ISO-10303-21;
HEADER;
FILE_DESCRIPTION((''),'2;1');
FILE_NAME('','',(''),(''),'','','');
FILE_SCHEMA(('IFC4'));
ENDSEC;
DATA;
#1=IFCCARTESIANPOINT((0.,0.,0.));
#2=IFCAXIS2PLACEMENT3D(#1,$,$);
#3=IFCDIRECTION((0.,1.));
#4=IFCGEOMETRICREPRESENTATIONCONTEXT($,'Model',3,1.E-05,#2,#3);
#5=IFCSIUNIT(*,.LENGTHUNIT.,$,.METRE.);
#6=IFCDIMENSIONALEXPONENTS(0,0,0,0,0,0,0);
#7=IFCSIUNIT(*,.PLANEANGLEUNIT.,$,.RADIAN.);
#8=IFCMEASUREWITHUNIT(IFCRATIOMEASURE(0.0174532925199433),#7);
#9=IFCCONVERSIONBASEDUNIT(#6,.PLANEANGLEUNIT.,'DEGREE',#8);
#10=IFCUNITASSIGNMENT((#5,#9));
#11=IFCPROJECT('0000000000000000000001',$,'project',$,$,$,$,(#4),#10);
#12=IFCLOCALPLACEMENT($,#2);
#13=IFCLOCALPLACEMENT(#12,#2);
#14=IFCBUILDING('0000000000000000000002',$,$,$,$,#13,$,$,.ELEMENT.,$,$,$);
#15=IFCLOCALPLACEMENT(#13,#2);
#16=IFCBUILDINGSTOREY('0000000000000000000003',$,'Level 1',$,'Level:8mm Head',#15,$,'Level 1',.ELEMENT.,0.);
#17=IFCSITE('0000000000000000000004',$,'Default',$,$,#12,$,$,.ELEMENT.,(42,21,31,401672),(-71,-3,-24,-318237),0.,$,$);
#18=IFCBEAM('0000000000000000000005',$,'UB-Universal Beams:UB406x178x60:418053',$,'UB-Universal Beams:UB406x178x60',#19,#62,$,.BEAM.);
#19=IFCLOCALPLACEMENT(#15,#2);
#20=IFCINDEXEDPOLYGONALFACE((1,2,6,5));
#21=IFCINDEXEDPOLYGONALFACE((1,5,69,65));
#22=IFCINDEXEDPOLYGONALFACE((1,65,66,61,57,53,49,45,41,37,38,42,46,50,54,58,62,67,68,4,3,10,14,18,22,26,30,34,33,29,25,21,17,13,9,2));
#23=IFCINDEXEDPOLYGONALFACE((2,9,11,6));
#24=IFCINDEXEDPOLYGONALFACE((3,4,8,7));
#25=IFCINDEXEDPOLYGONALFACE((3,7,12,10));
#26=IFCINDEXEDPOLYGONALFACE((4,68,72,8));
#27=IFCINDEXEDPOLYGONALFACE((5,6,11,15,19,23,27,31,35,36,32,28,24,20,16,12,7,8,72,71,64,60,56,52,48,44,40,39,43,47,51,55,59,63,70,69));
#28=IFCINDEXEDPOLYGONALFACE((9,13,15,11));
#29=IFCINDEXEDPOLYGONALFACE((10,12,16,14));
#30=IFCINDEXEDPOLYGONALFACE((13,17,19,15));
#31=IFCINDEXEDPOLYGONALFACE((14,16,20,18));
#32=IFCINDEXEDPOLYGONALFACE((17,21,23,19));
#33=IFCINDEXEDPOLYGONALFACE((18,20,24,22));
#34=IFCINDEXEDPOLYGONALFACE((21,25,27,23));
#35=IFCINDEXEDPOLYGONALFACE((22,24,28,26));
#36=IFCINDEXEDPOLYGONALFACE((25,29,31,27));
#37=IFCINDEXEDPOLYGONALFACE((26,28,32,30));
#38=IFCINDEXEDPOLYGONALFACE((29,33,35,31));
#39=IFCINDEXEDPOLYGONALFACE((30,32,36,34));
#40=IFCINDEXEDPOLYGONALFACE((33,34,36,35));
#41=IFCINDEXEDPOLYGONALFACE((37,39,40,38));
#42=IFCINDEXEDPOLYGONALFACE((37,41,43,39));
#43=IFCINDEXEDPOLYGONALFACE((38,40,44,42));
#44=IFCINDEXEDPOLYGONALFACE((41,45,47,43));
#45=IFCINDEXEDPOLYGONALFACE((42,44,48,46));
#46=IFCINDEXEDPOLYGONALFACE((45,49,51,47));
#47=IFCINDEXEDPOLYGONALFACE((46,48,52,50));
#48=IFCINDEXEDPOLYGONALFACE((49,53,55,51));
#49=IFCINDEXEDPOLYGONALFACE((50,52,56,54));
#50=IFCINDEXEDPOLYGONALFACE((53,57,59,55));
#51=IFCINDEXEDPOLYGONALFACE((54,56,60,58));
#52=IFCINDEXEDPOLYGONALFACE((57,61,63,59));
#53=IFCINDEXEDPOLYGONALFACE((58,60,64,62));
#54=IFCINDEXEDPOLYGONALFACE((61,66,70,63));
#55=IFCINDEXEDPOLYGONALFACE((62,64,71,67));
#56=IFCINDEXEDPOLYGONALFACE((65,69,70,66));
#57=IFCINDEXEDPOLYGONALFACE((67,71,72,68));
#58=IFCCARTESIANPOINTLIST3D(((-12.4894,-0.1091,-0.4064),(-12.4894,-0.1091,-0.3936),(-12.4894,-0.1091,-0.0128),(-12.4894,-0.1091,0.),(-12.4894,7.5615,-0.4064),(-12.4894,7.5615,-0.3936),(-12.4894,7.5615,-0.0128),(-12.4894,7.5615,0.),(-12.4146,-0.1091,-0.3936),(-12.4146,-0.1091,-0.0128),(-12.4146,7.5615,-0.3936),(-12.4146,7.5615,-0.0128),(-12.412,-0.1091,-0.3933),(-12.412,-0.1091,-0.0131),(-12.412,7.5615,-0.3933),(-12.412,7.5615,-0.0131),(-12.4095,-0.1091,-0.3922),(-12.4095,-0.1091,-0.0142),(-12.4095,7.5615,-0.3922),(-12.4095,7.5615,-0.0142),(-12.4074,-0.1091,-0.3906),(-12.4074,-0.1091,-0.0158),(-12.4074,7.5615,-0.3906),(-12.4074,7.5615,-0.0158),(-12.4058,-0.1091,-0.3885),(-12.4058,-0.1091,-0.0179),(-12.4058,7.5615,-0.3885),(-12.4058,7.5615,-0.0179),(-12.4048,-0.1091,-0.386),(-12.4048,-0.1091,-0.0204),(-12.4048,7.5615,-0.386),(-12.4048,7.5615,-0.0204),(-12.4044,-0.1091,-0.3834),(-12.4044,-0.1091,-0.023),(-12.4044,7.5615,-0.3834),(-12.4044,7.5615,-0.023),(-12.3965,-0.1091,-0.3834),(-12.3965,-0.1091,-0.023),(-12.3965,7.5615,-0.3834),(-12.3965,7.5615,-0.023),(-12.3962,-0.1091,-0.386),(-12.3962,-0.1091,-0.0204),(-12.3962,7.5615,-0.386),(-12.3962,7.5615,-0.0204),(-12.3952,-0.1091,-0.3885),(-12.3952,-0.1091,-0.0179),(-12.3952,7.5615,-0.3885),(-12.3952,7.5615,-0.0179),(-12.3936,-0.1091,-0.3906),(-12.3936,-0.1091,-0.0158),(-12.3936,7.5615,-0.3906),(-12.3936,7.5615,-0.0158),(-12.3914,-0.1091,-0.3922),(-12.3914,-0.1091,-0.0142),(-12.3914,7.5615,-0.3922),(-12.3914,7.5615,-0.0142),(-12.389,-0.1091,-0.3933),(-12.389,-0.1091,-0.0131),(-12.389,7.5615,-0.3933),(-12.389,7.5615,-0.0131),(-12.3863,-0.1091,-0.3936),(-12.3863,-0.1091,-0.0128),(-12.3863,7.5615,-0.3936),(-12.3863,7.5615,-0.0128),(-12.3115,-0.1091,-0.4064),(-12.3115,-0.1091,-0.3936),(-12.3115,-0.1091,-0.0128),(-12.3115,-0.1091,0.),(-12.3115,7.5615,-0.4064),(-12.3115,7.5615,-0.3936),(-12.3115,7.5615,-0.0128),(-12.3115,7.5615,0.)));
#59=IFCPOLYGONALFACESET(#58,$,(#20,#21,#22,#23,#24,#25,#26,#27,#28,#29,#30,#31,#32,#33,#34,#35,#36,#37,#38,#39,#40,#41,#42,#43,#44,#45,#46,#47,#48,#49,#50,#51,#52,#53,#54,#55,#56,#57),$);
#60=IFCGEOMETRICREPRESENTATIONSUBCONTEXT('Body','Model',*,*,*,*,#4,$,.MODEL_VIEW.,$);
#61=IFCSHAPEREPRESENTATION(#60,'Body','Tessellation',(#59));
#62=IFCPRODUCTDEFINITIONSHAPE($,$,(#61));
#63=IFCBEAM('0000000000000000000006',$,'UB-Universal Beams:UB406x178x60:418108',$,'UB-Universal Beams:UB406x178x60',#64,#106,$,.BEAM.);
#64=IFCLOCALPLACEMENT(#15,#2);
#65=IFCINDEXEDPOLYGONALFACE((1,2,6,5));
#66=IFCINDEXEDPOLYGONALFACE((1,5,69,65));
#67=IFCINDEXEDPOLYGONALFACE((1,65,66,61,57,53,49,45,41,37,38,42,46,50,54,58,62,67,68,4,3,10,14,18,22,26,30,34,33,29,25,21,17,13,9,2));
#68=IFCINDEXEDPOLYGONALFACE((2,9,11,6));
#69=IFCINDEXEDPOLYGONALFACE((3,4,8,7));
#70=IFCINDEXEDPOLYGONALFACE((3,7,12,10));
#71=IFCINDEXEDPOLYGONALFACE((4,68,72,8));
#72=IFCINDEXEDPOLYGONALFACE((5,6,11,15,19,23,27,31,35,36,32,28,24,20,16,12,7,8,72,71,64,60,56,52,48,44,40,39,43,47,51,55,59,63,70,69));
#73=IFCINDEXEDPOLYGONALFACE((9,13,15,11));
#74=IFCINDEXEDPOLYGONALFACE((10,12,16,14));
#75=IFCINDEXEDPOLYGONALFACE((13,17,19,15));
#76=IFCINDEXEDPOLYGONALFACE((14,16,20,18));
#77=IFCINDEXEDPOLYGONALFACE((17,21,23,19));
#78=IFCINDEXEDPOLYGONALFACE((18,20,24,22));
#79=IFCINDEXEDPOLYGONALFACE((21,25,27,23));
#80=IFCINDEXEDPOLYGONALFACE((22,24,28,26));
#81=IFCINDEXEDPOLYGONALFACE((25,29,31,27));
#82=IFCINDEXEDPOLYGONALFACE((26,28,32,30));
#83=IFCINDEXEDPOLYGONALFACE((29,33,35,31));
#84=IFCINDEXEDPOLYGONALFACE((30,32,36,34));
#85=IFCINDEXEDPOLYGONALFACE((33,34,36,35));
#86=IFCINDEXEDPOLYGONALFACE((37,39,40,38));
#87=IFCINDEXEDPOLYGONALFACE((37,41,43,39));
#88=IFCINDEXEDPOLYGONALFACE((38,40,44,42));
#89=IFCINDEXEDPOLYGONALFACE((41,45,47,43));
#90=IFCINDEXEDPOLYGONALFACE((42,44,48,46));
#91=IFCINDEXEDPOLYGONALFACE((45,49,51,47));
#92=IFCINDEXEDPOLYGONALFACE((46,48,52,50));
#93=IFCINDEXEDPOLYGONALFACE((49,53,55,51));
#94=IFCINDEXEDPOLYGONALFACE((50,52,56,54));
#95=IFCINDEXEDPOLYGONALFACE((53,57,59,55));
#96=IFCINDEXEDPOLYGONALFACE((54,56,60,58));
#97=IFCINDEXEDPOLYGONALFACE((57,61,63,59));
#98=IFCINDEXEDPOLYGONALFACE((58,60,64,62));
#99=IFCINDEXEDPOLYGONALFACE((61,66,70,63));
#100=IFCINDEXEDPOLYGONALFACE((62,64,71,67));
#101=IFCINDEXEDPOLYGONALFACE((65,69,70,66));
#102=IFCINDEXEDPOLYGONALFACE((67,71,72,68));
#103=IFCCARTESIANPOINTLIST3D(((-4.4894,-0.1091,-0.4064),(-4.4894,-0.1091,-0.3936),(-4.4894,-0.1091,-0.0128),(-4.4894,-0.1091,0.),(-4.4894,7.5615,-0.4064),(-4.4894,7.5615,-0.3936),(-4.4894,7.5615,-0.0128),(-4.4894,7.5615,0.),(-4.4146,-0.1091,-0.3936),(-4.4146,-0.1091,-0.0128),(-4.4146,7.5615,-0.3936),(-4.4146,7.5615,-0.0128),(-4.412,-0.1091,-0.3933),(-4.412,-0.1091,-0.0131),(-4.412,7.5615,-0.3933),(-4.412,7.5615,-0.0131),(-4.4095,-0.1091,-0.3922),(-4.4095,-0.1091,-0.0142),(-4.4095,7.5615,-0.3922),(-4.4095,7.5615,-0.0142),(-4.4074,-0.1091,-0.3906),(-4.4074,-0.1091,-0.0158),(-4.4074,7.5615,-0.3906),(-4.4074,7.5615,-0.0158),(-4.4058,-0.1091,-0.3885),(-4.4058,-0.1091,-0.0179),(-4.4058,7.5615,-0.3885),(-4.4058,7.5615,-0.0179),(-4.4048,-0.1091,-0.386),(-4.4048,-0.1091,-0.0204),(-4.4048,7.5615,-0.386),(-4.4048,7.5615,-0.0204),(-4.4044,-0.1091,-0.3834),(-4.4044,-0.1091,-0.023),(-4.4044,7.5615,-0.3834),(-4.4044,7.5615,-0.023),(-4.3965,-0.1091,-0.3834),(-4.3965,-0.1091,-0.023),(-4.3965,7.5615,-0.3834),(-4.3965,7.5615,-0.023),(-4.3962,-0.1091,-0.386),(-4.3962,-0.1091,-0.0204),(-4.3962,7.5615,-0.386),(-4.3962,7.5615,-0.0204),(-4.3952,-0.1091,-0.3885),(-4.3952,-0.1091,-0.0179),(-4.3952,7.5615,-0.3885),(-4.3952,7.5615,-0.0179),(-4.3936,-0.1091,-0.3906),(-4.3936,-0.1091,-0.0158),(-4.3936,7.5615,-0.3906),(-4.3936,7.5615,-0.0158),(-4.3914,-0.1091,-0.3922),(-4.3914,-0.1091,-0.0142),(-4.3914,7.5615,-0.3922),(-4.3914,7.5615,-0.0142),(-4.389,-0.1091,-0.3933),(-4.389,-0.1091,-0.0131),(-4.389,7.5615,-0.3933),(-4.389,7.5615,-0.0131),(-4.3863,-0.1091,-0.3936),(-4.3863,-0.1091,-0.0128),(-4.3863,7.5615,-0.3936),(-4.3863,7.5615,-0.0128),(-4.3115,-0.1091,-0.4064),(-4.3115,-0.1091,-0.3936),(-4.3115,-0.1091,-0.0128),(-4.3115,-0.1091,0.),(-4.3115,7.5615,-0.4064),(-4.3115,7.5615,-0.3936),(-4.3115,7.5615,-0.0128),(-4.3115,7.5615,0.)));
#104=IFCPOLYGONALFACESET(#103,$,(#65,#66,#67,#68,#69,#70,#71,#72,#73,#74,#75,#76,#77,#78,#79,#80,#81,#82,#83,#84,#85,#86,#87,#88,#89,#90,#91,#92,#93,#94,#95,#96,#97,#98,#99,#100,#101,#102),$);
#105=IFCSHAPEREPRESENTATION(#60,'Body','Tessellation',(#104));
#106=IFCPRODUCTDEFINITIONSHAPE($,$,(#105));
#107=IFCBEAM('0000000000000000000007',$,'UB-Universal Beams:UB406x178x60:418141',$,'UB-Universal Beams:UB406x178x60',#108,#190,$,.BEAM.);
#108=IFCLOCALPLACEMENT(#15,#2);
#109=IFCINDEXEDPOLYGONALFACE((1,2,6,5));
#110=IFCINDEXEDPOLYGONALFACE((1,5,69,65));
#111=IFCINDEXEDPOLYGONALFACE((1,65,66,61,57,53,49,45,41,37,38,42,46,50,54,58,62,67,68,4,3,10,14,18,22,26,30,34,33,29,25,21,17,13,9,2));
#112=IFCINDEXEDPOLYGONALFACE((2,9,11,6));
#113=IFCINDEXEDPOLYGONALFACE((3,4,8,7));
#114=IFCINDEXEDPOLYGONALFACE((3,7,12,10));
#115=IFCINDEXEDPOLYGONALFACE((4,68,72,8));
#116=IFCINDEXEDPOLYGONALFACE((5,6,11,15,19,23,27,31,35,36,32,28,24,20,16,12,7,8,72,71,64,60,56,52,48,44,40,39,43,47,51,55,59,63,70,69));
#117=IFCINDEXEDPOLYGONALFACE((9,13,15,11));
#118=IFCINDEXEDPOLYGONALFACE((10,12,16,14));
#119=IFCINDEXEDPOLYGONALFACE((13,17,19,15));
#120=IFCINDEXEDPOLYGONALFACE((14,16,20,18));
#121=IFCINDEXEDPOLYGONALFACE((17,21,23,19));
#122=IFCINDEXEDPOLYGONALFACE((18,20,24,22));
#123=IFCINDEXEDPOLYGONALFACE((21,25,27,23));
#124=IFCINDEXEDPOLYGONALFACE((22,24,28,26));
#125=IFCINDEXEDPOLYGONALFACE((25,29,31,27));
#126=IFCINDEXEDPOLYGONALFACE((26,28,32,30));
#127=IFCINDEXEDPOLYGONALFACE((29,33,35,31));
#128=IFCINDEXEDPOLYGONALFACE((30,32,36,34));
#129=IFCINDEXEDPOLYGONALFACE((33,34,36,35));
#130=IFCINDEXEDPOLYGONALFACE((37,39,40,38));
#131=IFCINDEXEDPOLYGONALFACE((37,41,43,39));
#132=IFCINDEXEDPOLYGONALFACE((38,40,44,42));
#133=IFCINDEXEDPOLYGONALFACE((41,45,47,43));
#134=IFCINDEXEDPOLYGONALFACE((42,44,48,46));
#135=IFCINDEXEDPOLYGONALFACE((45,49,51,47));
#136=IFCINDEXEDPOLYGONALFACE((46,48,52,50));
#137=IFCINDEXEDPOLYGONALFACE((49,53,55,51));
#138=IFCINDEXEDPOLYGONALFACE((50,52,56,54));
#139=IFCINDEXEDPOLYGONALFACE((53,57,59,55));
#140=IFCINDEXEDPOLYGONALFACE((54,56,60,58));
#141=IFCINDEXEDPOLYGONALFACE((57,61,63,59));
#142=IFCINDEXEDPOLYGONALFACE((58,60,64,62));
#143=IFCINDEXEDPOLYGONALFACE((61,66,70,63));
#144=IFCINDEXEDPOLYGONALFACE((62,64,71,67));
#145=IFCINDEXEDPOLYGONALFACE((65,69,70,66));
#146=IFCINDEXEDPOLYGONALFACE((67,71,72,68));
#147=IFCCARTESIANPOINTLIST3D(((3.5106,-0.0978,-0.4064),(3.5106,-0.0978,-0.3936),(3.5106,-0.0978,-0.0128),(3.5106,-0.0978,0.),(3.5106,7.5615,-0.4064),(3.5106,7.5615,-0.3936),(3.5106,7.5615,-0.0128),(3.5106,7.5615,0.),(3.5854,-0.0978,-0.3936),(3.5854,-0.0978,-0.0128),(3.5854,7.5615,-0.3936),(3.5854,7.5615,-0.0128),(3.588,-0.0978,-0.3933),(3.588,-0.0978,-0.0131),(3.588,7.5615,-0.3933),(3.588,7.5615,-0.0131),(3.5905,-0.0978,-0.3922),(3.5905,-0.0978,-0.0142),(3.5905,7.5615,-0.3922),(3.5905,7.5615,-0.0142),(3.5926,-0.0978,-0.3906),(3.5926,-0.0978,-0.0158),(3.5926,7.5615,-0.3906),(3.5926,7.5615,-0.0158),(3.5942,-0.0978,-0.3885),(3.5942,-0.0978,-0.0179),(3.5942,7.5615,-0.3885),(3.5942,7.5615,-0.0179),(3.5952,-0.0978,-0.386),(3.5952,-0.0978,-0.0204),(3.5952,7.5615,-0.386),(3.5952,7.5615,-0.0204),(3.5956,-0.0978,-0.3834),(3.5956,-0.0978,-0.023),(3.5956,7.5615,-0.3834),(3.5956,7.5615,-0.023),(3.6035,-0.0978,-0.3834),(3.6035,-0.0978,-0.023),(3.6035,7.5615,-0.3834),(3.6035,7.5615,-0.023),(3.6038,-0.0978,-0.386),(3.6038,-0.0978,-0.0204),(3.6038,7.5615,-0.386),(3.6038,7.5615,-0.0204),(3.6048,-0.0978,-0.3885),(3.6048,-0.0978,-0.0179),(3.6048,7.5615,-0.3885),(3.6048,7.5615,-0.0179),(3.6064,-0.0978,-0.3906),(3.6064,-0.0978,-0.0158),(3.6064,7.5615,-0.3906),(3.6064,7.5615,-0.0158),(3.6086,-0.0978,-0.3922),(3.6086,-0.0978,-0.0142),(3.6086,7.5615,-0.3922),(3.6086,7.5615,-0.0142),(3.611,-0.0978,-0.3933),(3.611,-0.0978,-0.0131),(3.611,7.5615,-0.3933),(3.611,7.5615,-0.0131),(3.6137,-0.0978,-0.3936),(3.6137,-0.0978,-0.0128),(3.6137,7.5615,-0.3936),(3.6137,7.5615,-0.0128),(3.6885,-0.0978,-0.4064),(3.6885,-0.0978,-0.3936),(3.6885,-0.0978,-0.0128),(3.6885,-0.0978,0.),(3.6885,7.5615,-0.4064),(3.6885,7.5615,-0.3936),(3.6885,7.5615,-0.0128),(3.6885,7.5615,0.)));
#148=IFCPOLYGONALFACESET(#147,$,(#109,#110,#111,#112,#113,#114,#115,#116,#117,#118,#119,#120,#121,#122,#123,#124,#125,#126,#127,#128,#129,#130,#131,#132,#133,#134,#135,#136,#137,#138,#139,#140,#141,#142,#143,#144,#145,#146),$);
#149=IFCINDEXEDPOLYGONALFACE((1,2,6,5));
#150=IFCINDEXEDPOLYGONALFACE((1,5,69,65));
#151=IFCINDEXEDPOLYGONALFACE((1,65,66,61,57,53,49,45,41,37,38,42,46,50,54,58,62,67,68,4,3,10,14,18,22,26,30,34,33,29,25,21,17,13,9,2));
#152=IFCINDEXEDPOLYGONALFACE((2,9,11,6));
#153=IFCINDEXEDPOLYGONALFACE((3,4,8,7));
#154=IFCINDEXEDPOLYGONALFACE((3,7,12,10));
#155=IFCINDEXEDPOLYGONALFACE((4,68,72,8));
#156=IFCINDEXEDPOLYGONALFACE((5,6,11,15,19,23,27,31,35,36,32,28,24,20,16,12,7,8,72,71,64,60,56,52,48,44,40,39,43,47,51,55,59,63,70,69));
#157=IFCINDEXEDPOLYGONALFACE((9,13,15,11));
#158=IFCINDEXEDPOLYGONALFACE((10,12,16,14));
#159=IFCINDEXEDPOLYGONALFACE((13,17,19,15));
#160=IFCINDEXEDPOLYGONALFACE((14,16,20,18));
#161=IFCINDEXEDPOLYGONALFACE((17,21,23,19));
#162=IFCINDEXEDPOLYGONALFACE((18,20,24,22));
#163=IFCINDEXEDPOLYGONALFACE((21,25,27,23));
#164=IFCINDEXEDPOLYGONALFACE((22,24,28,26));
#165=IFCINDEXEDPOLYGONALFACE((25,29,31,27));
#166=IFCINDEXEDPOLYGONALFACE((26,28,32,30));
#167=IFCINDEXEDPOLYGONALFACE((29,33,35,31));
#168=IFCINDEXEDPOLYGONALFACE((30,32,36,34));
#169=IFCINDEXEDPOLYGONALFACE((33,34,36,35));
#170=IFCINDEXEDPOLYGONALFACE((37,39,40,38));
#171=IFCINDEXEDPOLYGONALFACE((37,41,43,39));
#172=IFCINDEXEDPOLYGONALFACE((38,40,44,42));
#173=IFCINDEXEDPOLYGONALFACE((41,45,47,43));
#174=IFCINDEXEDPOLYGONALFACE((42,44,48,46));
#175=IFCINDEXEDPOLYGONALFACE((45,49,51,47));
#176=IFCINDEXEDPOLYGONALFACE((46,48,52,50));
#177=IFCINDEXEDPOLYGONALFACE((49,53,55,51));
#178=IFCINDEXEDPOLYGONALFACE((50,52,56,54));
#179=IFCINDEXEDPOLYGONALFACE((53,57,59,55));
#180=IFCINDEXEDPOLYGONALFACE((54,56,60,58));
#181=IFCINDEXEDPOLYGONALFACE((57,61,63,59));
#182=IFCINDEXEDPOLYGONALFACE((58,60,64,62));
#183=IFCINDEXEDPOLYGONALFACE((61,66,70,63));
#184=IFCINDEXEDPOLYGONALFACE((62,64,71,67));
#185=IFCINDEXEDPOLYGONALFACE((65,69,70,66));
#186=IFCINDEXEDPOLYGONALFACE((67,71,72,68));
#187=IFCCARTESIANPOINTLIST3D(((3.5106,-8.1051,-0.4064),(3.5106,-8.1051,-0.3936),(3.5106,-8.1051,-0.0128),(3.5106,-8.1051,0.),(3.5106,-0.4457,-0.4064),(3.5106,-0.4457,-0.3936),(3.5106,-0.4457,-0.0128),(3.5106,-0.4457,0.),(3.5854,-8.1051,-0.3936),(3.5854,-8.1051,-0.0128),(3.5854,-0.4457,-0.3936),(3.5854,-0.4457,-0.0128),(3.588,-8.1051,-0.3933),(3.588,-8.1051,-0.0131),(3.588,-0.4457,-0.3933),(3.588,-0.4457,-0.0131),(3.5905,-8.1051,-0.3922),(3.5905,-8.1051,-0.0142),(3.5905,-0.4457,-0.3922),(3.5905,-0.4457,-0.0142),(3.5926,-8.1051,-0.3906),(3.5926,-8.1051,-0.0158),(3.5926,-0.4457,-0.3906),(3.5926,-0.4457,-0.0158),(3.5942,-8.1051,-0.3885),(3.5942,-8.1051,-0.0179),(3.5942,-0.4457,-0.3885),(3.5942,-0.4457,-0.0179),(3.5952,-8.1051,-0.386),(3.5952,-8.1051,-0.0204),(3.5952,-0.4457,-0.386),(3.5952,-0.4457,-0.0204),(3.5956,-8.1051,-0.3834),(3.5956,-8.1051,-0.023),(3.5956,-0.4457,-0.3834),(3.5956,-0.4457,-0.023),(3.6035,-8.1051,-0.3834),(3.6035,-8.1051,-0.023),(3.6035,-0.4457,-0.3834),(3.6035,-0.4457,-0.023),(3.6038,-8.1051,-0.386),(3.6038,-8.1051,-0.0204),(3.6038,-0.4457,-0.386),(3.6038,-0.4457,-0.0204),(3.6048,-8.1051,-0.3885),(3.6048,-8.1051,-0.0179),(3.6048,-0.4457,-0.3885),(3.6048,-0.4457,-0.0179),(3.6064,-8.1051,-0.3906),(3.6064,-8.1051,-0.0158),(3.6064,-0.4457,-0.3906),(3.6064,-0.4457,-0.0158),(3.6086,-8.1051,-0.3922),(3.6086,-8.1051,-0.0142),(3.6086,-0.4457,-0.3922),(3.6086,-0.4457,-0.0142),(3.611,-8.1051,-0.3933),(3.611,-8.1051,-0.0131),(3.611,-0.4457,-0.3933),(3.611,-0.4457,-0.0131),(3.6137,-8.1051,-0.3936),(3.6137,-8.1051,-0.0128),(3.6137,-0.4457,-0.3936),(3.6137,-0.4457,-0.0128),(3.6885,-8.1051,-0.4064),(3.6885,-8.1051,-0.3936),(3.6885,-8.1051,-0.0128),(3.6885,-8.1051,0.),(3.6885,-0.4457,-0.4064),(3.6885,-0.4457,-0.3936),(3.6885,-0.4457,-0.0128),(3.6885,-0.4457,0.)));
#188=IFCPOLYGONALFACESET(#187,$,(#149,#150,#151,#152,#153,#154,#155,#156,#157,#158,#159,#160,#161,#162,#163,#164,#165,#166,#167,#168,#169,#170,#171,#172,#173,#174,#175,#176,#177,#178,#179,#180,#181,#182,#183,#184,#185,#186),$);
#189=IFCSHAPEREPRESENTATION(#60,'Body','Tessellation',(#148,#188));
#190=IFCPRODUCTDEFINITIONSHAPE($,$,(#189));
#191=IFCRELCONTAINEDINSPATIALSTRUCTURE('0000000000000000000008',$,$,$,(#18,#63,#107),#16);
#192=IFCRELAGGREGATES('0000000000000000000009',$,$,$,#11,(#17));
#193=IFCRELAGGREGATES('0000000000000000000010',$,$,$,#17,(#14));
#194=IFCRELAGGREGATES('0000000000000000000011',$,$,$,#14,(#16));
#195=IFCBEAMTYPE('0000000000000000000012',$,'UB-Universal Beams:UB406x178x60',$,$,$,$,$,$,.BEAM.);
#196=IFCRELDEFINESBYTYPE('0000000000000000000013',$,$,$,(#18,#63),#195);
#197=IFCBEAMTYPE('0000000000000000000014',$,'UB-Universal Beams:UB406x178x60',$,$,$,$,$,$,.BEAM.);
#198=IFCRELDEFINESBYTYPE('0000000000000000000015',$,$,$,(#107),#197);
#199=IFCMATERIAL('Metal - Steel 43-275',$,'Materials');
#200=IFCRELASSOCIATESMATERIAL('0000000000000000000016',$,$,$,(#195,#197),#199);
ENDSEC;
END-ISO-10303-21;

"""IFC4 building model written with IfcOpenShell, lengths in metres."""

from ifc_helpers import new_model, entity, si_unit, converted_unit, direction, frame, frame_2d, origin, place, context, subcontext, project, spatial, i_section, extrude, source, transform, mapped, material, material_profile, profile_set, type_object, type_shapes, element, save


model = new_model("IFC4")

# Units and contexts
model_context = context("Model", 3, precision=1e-05, world=origin(), true_north=direction((0.0, 1.0)))
body_context = subcontext(model_context, "Body", "Model", "MODEL_VIEW")
ifc_project = project(units=[si_unit("LENGTHUNIT", "METRE"), converted_unit("PLANEANGLEUNIT", "DEGREE", entity("IfcRatioMeasure", 0.0174532925199433), si_unit("PLANEANGLEUNIT", "RADIAN"), dimensions=[0, 0, 0, 0, 0, 0, 0])], contexts=[model_context])

# Site, building, storey
site_placement = place(None, origin())
site = spatial("IfcSite", under=ifc_project, at=site_placement, Name="Default", CompositionType="ELEMENT", RefLatitude=(42, 21, 31, 401672), RefLongitude=(-71, -3, -24, -318237), RefElevation=0.0)
building_placement = place(site_placement, origin())
building = spatial("IfcBuilding", under=site, at=building_placement, CompositionType="ELEMENT")
storey_placement = place(building_placement, origin())
storey = spatial("IfcBuildingStorey", under=building, at=storey_placement, Name="Level 1", ObjectType="Level:8mm Head", LongName="Level 1", CompositionType="ELEMENT", Elevation=0.0)

# Beams
ifc_material_1 = material(Name="Metal - Steel 43-275", Category="Materials")
ifc_material_profile_1 = material_profile(ifc_material_1, i_section(OverallWidth=0.1779, OverallDepth=0.4064, WebThickness=0.0079, FlangeThickness=0.0128, FilletRadius=0.0102, at=frame_2d((0.0, 0.0), x_axis=(0.0, 1.0))), Name="UB406x178x60")
ifc_profile_set_1 = profile_set([ifc_material_profile_1], Name="UB406x178x60")
beam_type_1 = type_object("IfcBeamType", Name="UB-Universal Beams:UB406x178x60", PredefinedType="BEAM", material=ifc_profile_set_1)
shared_shape_1 = source(origin(), body_context, "Body", "SweptSolid", [
    extrude(i_section(OverallWidth=0.1779, OverallDepth=0.4064, WebThickness=0.0079, FlangeThickness=0.0128, FilletRadius=0.0102, at=frame_2d((0.0, 0.0), x_axis=(0.0, 1.0))), frame((-3.8373, 0.0, 0.0), z_axis=(1.0, 0.0, 0.0), x_axis=(0.0, 0.0, -1.0)), (0.0, 0.0, 1.0), 7.6706),
])
type_shapes(beam_type_1, [shared_shape_1])
for number, where, z_axis, x_axis, name in (
    (1, (-12.4005, 3.7282, -0.2032), (0.0, 0.0, 1.0), (0.0, 1.0, 0.0), "UB-Universal Beams:UB406x178x60:418053"),
    (2, (-4.4005, 3.7282, -0.2032), (0.0, 0.0, 1.0), (0.0, 1.0, 0.0), "UB-Universal Beams:UB406x178x60:418108"),
):
    element("IfcBeam", number, at=place(storey_placement, frame(where, z_axis=z_axis, x_axis=x_axis)), inside=storey, type_object=beam_type_1, Name=name, ObjectType="UB-Universal Beams:UB406x178x60", PredefinedType="BEAM", context=body_context, shape_type="MappedRepresentation", body=[
        mapped(shared_shape_1, transform((0.0, 0.0, 0.0), scale=1.0)),
    ])
beam_type_2 = type_object("IfcBeamType", Name="UB-Universal Beams:UB406x178x60", PredefinedType="BEAM", material=ifc_profile_set_1)
shared_shape_2 = source(origin(), body_context, "Body", "SweptSolid", [
    extrude(i_section(OverallWidth=0.1779, OverallDepth=0.4064, WebThickness=0.0079, FlangeThickness=0.0128, FilletRadius=0.0102, at=frame_2d((0.0, 0.0), x_axis=(1.0, 0.0))), frame((3.5995, -0.0978, -0.2032), z_axis=(0.0, 1.0, 0.0), x_axis=(-1.0, 0.0, 0.0)), (0.0, 0.0, 1.0), 7.6593),
    extrude(i_section(OverallWidth=0.1779, OverallDepth=0.4064, WebThickness=0.0079, FlangeThickness=0.0128, FilletRadius=0.0102, at=frame_2d((0.0, 0.0), x_axis=(1.0, 0.0))), frame((3.5995, -8.1051, -0.2032), z_axis=(0.0, 1.0, 0.0), x_axis=(-1.0, 0.0, 0.0)), (0.0, 0.0, 1.0), 7.6593),
])
type_shapes(beam_type_2, [shared_shape_2])
beam_1_placement = place(storey_placement, origin())
element("IfcBeam", 3, at=beam_1_placement, inside=storey, type_object=beam_type_2, Name="UB-Universal Beams:UB406x178x60:418141", ObjectType="UB-Universal Beams:UB406x178x60", PredefinedType="BEAM", context=body_context, shape_type="MappedRepresentation", body=[
    mapped(shared_shape_2, transform((0.0, 0.0, 0.0), scale=1.0)),
])

save(model, "model.ifc")
